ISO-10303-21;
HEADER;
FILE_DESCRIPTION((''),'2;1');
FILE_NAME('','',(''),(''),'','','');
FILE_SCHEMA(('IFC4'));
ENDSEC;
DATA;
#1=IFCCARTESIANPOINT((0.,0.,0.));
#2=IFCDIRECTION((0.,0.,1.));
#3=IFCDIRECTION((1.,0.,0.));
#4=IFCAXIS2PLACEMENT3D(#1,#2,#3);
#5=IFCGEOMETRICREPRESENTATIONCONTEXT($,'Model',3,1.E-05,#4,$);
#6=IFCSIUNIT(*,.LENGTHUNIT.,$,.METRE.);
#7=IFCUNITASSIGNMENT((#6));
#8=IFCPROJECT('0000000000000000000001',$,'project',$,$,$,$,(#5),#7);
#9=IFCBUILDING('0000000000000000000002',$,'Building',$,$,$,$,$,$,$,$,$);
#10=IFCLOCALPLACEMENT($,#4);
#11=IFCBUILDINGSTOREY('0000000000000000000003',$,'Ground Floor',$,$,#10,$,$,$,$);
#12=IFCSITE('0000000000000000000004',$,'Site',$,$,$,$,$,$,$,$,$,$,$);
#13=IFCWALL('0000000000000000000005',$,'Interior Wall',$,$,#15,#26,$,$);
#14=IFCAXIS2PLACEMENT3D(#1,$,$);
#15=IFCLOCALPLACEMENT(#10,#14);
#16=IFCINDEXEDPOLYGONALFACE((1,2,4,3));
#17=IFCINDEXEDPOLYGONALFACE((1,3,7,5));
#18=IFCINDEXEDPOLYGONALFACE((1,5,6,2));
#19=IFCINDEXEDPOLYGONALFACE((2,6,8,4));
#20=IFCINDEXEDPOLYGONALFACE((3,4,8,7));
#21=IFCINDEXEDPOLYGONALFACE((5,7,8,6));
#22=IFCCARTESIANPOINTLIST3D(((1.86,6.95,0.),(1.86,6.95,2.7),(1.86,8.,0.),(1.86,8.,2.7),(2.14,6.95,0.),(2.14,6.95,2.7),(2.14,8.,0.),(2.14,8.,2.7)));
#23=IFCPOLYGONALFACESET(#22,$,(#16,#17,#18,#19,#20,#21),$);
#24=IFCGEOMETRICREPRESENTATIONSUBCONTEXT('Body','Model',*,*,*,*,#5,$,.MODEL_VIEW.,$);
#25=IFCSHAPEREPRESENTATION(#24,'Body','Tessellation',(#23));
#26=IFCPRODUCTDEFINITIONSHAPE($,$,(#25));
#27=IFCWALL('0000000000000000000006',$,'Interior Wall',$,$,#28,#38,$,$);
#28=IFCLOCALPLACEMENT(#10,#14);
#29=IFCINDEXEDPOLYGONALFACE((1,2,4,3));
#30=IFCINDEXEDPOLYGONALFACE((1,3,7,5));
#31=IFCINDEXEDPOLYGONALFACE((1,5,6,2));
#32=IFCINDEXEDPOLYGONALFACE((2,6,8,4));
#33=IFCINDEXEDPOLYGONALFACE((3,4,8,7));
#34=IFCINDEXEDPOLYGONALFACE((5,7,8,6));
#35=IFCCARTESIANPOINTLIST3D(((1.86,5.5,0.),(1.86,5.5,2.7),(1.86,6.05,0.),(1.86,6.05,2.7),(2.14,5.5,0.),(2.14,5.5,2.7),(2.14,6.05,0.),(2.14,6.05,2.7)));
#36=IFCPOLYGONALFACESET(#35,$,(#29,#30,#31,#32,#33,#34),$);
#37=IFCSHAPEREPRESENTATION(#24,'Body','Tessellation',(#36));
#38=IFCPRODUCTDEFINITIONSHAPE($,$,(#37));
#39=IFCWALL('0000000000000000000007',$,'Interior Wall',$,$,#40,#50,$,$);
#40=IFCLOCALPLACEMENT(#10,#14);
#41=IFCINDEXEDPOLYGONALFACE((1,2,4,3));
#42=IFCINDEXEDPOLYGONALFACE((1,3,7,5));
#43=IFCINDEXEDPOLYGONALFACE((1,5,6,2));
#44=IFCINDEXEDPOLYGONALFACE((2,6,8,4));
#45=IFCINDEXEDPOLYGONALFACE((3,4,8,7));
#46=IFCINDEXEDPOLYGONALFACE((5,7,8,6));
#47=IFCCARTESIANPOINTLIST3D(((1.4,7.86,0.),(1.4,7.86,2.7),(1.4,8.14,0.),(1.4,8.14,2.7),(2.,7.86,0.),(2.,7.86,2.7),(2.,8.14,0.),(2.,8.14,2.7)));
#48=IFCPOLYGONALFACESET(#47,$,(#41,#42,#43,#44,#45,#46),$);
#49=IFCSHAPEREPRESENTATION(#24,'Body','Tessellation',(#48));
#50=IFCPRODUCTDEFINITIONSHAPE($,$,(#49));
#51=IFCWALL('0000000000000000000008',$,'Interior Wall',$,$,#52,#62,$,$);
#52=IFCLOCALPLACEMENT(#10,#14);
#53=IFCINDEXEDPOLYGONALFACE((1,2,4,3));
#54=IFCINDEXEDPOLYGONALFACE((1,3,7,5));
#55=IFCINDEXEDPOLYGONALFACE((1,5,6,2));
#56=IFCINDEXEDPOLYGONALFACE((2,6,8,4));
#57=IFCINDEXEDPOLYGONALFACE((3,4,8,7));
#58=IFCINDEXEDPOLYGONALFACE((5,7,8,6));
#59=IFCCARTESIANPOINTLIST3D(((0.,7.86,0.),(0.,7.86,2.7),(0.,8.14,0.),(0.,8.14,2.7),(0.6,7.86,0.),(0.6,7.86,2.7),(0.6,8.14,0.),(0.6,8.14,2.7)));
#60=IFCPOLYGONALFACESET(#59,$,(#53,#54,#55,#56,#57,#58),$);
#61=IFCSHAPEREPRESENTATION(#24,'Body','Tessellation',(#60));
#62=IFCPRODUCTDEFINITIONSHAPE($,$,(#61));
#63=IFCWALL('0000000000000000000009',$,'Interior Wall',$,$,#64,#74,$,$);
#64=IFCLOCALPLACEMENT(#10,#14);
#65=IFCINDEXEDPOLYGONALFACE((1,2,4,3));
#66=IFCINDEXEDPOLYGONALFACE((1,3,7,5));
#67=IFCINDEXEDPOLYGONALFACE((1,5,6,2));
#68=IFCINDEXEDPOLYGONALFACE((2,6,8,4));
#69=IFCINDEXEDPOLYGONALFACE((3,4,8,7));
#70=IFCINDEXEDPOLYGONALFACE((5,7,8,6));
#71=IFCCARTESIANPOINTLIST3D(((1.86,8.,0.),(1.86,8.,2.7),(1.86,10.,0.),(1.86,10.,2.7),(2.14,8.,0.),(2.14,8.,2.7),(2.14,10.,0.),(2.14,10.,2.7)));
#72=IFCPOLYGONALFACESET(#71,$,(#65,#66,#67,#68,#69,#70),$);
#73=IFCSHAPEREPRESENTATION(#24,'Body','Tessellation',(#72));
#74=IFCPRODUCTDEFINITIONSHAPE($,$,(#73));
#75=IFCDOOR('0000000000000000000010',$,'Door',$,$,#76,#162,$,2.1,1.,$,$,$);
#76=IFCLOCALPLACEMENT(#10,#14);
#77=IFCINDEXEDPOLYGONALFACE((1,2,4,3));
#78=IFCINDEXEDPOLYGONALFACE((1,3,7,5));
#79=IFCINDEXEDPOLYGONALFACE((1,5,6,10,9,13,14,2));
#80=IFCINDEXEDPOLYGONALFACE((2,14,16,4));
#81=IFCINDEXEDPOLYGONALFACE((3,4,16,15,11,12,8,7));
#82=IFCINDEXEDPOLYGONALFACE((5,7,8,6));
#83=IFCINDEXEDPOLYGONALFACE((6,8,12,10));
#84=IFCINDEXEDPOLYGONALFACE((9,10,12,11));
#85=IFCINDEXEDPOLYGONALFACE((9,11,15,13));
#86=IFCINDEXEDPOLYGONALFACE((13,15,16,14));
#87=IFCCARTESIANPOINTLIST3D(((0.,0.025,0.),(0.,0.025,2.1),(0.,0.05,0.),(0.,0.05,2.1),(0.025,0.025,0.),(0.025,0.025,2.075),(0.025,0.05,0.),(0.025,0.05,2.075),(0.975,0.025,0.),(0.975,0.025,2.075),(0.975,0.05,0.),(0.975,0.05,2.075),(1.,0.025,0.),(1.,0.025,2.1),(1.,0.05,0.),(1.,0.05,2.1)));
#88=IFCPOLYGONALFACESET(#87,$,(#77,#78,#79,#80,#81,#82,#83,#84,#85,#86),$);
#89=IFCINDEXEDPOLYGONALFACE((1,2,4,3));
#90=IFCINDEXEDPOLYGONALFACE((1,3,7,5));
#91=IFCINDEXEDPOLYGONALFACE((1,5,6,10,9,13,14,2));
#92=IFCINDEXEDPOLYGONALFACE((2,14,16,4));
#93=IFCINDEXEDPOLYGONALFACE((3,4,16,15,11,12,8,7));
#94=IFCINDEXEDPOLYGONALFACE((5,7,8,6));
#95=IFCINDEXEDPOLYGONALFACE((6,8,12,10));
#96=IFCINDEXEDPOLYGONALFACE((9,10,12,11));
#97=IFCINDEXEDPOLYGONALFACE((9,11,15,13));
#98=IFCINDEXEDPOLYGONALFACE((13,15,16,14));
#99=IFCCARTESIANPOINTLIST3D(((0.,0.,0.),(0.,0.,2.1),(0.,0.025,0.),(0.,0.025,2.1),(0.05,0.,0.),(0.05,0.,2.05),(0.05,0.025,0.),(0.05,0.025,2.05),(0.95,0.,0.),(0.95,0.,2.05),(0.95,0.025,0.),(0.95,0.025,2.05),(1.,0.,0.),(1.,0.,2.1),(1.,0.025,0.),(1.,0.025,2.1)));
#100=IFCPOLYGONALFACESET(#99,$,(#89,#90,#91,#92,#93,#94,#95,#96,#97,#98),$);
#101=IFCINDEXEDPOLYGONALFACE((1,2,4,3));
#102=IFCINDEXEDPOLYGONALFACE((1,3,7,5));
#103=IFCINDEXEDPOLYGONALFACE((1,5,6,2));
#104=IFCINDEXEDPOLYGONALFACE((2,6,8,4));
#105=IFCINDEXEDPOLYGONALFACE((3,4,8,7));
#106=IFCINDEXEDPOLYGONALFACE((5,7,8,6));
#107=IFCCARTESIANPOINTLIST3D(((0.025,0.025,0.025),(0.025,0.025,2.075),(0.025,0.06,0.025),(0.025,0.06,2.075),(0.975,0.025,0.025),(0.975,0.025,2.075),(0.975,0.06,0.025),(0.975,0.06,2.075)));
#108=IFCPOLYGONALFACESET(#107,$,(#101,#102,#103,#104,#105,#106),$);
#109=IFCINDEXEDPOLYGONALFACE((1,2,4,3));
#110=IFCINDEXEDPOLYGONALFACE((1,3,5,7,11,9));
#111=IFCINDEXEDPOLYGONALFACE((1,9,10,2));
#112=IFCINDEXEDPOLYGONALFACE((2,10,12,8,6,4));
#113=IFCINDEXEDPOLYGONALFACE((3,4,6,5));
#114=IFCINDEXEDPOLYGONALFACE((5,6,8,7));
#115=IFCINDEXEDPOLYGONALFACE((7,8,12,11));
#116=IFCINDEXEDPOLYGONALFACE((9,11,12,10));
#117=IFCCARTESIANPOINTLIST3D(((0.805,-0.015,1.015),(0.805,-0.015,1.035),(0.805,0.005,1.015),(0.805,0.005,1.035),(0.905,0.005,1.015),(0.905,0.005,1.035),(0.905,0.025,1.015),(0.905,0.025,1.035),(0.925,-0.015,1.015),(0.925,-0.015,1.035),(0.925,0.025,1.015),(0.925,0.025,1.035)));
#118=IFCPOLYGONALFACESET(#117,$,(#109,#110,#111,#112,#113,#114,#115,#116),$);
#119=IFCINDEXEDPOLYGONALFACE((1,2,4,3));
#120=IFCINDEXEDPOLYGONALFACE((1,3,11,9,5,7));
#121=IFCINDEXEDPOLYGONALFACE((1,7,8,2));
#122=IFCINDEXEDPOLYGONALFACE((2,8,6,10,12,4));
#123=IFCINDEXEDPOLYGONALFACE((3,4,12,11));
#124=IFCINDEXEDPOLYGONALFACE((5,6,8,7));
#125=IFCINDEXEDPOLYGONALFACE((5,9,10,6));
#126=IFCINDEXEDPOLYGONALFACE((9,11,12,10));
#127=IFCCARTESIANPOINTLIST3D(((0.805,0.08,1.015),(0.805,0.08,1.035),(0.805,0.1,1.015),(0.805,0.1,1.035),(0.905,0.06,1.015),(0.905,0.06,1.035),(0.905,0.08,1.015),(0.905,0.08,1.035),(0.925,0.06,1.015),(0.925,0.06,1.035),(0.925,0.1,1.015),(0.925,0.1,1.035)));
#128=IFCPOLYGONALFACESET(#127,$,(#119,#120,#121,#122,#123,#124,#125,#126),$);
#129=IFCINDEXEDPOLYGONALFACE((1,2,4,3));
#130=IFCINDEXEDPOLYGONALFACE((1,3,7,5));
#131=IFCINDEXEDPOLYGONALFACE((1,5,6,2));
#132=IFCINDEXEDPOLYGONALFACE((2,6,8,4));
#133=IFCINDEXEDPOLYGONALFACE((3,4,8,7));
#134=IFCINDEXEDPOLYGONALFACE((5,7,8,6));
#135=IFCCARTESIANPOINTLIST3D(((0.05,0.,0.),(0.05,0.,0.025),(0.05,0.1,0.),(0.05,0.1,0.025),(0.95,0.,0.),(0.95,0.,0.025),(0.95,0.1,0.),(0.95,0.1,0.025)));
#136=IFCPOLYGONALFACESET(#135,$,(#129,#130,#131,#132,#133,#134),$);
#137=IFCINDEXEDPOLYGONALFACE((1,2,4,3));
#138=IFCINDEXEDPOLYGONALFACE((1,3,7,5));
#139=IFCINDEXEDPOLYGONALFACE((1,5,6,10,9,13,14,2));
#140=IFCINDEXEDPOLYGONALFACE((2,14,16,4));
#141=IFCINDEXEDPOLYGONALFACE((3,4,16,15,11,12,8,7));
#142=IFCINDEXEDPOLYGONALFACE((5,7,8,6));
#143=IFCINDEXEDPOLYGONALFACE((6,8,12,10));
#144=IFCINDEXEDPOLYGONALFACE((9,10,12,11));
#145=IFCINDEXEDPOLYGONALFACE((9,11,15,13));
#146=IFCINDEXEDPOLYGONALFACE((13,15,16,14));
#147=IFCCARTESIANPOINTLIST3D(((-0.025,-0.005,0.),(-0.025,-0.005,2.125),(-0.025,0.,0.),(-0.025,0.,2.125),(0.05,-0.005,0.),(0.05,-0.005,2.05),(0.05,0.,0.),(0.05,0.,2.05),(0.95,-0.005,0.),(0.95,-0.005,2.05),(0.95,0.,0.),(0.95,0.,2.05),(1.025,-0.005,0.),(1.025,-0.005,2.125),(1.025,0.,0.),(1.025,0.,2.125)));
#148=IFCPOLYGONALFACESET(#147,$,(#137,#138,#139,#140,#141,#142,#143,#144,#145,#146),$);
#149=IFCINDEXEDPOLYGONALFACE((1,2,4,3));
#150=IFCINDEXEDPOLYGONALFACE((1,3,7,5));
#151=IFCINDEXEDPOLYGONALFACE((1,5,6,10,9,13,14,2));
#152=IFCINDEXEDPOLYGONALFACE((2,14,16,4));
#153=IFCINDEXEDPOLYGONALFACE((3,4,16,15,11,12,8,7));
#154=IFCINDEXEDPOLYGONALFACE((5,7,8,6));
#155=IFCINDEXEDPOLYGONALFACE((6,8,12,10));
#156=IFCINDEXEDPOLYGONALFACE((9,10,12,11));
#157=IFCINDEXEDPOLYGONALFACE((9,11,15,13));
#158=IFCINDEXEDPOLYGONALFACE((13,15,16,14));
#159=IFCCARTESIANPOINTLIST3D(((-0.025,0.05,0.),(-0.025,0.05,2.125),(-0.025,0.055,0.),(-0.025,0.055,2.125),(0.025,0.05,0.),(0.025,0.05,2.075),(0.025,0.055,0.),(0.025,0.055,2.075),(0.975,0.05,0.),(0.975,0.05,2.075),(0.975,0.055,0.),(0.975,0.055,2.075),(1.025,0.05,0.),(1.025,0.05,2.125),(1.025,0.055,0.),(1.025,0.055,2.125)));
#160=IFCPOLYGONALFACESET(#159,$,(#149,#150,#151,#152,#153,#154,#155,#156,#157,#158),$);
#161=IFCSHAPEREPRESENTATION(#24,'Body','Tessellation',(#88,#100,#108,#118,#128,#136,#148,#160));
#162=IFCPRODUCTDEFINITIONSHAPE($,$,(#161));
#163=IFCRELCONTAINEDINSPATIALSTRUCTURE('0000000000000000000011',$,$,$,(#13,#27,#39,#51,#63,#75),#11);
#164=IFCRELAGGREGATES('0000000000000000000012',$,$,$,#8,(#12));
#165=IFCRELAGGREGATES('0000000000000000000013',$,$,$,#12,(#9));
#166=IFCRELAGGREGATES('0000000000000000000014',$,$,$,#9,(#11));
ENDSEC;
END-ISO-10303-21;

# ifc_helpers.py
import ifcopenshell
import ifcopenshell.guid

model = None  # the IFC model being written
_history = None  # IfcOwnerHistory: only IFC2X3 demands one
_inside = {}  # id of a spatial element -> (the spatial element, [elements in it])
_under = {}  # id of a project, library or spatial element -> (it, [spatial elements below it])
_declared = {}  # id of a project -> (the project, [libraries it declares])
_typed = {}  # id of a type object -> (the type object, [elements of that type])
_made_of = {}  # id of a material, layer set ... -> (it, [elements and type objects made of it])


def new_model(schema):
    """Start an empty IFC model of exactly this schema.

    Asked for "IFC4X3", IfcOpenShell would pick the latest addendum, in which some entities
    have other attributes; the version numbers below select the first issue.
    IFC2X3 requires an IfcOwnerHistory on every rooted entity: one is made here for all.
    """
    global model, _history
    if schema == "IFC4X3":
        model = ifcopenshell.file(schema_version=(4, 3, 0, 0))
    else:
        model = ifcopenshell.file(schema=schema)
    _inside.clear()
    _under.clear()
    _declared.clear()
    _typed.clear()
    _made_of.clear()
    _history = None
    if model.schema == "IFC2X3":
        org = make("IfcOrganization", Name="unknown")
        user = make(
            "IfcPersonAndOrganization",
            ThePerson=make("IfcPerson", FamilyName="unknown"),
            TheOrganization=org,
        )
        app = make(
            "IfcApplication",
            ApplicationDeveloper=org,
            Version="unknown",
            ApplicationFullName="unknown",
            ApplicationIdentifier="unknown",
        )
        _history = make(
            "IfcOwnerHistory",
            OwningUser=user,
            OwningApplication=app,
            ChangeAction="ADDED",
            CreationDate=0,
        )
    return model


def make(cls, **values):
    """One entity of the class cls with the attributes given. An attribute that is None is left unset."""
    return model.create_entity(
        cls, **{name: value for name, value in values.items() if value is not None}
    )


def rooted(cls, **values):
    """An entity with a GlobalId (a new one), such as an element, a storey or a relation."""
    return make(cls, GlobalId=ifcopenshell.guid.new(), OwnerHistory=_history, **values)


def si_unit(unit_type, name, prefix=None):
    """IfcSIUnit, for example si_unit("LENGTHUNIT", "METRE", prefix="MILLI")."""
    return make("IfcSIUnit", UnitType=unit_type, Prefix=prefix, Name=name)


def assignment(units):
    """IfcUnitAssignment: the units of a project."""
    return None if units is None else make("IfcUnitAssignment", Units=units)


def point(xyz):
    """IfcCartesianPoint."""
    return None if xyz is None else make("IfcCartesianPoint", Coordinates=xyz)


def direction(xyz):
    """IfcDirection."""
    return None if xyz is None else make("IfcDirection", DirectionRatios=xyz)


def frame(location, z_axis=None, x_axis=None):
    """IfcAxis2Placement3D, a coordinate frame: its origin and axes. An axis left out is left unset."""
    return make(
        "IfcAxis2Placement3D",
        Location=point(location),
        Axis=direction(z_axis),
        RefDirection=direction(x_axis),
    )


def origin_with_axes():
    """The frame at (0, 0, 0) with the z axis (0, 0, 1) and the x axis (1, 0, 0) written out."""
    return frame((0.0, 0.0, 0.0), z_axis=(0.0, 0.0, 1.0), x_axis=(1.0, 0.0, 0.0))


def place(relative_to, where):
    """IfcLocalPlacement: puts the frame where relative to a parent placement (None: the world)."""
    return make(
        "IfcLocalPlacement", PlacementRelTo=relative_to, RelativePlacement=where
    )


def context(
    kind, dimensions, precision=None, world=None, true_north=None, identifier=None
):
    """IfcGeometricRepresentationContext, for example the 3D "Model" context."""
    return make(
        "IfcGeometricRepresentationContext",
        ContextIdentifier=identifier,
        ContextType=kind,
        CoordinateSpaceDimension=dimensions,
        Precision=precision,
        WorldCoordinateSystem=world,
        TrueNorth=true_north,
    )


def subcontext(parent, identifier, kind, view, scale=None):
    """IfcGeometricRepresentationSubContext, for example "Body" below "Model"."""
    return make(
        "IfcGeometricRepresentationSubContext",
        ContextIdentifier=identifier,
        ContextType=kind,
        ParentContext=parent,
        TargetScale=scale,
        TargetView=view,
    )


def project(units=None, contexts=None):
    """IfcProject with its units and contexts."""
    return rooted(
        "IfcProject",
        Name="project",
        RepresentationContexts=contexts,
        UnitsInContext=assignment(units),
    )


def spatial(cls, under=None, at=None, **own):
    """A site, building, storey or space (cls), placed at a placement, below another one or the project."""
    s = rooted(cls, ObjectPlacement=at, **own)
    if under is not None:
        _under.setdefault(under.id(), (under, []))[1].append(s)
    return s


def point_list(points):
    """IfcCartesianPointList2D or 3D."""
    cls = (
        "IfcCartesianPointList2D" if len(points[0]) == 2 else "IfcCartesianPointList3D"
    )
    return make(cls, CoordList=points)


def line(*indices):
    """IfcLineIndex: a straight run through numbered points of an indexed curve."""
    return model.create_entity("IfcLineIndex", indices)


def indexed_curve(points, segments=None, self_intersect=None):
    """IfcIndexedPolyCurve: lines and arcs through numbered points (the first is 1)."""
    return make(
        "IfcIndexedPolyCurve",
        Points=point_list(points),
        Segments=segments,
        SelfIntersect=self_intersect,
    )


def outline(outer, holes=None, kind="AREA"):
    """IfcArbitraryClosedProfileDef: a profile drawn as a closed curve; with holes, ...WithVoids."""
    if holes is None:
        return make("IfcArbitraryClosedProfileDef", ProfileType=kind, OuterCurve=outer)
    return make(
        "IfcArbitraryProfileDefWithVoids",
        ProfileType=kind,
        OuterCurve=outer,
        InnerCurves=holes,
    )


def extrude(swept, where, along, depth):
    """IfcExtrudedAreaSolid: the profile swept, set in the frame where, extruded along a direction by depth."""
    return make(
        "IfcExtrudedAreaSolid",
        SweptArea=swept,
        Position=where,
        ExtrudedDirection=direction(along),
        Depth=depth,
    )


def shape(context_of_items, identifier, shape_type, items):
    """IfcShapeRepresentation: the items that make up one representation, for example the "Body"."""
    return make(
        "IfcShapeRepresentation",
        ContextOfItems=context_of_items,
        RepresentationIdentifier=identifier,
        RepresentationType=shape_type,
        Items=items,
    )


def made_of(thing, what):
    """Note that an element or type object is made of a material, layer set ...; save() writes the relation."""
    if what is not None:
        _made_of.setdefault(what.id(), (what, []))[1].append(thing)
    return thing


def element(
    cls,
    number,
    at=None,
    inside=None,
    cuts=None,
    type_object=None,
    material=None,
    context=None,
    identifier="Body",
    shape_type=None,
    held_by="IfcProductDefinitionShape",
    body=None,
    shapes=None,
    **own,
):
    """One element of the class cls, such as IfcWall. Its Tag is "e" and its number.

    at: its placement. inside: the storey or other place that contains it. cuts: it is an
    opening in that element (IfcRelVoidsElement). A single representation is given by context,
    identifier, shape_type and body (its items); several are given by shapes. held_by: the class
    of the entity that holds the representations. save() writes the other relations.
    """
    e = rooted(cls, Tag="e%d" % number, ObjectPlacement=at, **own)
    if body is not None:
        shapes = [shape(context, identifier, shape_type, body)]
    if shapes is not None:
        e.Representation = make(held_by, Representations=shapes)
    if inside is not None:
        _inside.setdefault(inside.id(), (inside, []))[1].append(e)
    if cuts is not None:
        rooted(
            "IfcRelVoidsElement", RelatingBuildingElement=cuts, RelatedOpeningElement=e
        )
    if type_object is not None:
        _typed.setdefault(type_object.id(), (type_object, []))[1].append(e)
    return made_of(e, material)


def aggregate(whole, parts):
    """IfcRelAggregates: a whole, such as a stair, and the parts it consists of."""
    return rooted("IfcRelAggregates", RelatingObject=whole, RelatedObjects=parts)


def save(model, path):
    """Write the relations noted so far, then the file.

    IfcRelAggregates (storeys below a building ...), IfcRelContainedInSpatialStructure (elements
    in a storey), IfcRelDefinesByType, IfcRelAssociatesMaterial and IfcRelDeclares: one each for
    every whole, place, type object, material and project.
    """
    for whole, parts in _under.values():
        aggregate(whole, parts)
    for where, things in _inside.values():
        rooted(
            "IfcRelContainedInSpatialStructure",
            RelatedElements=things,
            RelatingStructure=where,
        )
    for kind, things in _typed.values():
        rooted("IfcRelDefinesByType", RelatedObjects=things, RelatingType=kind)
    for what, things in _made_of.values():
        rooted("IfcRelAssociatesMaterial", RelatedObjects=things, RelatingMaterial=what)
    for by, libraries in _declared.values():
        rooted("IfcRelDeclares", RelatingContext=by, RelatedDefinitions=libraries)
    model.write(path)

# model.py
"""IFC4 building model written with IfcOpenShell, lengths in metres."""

from ifc_helpers import new_model, si_unit, frame, origin_with_axes, place, context, subcontext, project, spatial, line, indexed_curve, outline, extrude, element, save


model = new_model("IFC4")

# Units and contexts
model_context = context("Model", 3, precision=1e-05, world=origin_with_axes())
body_context = subcontext(model_context, "Body", "Model", "MODEL_VIEW")
ifc_project = project(units=[si_unit("LENGTHUNIT", "METRE")], contexts=[model_context])

# Site, building, storey
site = spatial("IfcSite", under=ifc_project, Name="Site")
building = spatial("IfcBuilding", under=site, Name="Building")
storey_placement = place(None, origin_with_axes())
storey = spatial("IfcBuildingStorey", under=building, at=storey_placement, Name="Ground Floor")

# Walls
wall_1_placement = place(storey_placement, frame((2.0, 8.0, 0.0), z_axis=(0.0, 0.0, 1.0), x_axis=(0.0, -1.0, 0.0)))
element("IfcWall", 1, at=wall_1_placement, inside=storey, Name="Interior Wall", context=body_context, shape_type="SweptSolid", body=[
    extrude(outline(indexed_curve([(0.0, 0.0), (0.0, 0.28), (1.05, 0.28), (1.05, 0.0), (0.0, 0.0)], self_intersect=False)), frame((0.0, -0.14, 0.0), z_axis=(0.0, 0.0, 1.0), x_axis=(1.0, 0.0, 0.0)), (0.0, 0.0, 1.0), 2.7),
])
wall_2_placement = place(storey_placement, frame((2.0, 6.05, 0.0), z_axis=(0.0, 0.0, 1.0), x_axis=(0.0, -1.0, 0.0)))
element("IfcWall", 2, at=wall_2_placement, inside=storey, Name="Interior Wall", context=body_context, shape_type="SweptSolid", body=[
    extrude(outline(indexed_curve([(0.0, 0.0), (0.0, 0.28), (0.55, 0.28), (0.55, 0.0), (0.0, 0.0)], self_intersect=False)), frame((0.0, -0.14, 0.0), z_axis=(0.0, 0.0, 1.0), x_axis=(1.0, 0.0, 0.0)), (0.0, 0.0, 1.0), 2.7),
])
for number, where, z_axis, x_axis, name in (
    (3, (2.0, 8.0, 0.0), (0.0, 0.0, 1.0), (-1.0, 0.0, 0.0), "Interior Wall"),
    (4, (0.6, 8.0, 0.0), (0.0, 0.0, 1.0), (-1.0, 0.0, 0.0), "Interior Wall"),
):
    element("IfcWall", number, at=place(storey_placement, frame(where, z_axis=z_axis, x_axis=x_axis)), inside=storey, Name=name, context=body_context, shape_type="SweptSolid", body=[
        extrude(outline(indexed_curve([(0.0, 0.0), (0.0, 0.28), (0.6, 0.28), (0.6, 0.0), (0.0, 0.0)], self_intersect=False)), frame((0.0, -0.14, 0.0), z_axis=(0.0, 0.0, 1.0), x_axis=(1.0, 0.0, 0.0)), (0.0, 0.0, 1.0), 2.7),
    ])
wall_3_placement = place(storey_placement, frame((2.0, 10.0, 0.0), z_axis=(0.0, 0.0, 1.0), x_axis=(0.0, -1.0, 0.0)))
element("IfcWall", 5, at=wall_3_placement, inside=storey, Name="Interior Wall", context=body_context, shape_type="SweptSolid", body=[
    extrude(outline(indexed_curve([(0.0, 0.0), (0.0, 0.28), (2.0, 0.28), (2.0, 0.0), (0.0, 0.0)], self_intersect=False)), frame((0.0, -0.14, 0.0), z_axis=(0.0, 0.0, 1.0), x_axis=(1.0, 0.0, 0.0)), (0.0, 0.0, 1.0), 2.7),
])

# Door
door_1_placement = place(storey_placement, origin_with_axes())
element("IfcDoor", 6, at=door_1_placement, inside=storey, Name="Door", OverallHeight=2.1, OverallWidth=1.0, context=body_context, shape_type="SweptSolid", body=[
    extrude(outline(indexed_curve([(0.0, 0.0), (0.0, 2.1), (1.0, 2.1), (1.0, 0.0), (0.975, 0.0), (0.975, 2.075), (0.025, 2.075), (0.025, 0.0)], segments=[line(1, 2, 3, 4, 5, 6, 7, 8, 1)])), frame((0.0, 0.025, 0.0), z_axis=(0.0, -1.0, 0.0), x_axis=(1.0, 0.0, 0.0)), (0.0, 0.0, -1.0), 0.025),
    extrude(outline(indexed_curve([(0.0, 0.0), (0.0, 2.1), (1.0, 2.1), (1.0, 0.0), (0.95, 0.0), (0.95, 2.05), (0.05, 2.05), (0.05, 0.0)], segments=[line(1, 2, 3, 4, 5, 6, 7, 8, 1)])), frame((0.0, 0.0, 0.0), z_axis=(0.0, -1.0, 0.0), x_axis=(1.0, 0.0, 0.0)), (0.0, 0.0, -1.0), 0.025),
    extrude(outline(indexed_curve([(0.0, 0.0), (0.95, 0.0), (0.95, 0.035), (0.0, 0.035)], segments=[line(1, 2, 3, 4, 1)])), frame((0.025, 0.025, 0.025), z_axis=(0.0, 0.0, 1.0), x_axis=(1.0, 0.0, 0.0)), (0.0, 0.0, 1.0), 2.05),
    extrude(outline(indexed_curve([(0.0, 0.0), (0.0, -0.04), (-0.12, -0.04), (-0.12, -0.02), (-0.02, -0.02), (-0.02, 0.0)], segments=[line(1, 2, 3, 4, 5, 6, 1)])), frame((0.925, 0.025, 1.015), z_axis=(0.0, 0.0, 1.0), x_axis=(1.0, 0.0, 0.0)), (0.0, 0.0, 1.0), 0.02),
    extrude(outline(indexed_curve([(0.0, 0.0), (0.0, 0.04), (-0.12, 0.04), (-0.12, 0.02), (-0.02, 0.02), (-0.02, 0.0)], segments=[line(1, 2, 3, 4, 5, 6, 1)])), frame((0.925, 0.06, 1.015), z_axis=(0.0, 0.0, 1.0), x_axis=(1.0, 0.0, 0.0)), (0.0, 0.0, 1.0), 0.02),
    extrude(outline(indexed_curve([(0.0, 0.0), (0.9, 0.0), (0.9, 0.1), (0.0, 0.1)], segments=[line(1, 2, 3, 4, 1)])), frame((0.05, 0.0, 0.0), z_axis=(0.0, 0.0, 1.0), x_axis=(1.0, 0.0, 0.0)), (0.0, 0.0, 1.0), 0.025),
    extrude(outline(indexed_curve([(0.0, 0.0), (0.0, 2.125), (1.05, 2.125), (1.05, 0.0), (0.975, 0.0), (0.975, 2.05), (0.075, 2.05), (0.075, 0.0)], segments=[line(1, 2, 3, 4, 5, 6, 7, 8, 1)])), frame((-0.025, -0.005, 0.0), z_axis=(0.0, -1.0, 0.0), x_axis=(1.0, 0.0, 0.0)), (0.0, 0.0, -1.0), 0.005),
    extrude(outline(indexed_curve([(0.0, 0.0), (0.0, 2.125), (1.05, 2.125), (1.05, 0.0), (1.0, 0.0), (1.0, 2.075), (0.05, 2.075), (0.05, 0.0)], segments=[line(1, 2, 3, 4, 5, 6, 7, 8, 1)])), frame((-0.025, 0.05, 0.0), z_axis=(0.0, -1.0, 0.0), x_axis=(1.0, 0.0, 0.0)), (0.0, 0.0, -1.0), 0.005),
])

save(model, "model.ifc")
